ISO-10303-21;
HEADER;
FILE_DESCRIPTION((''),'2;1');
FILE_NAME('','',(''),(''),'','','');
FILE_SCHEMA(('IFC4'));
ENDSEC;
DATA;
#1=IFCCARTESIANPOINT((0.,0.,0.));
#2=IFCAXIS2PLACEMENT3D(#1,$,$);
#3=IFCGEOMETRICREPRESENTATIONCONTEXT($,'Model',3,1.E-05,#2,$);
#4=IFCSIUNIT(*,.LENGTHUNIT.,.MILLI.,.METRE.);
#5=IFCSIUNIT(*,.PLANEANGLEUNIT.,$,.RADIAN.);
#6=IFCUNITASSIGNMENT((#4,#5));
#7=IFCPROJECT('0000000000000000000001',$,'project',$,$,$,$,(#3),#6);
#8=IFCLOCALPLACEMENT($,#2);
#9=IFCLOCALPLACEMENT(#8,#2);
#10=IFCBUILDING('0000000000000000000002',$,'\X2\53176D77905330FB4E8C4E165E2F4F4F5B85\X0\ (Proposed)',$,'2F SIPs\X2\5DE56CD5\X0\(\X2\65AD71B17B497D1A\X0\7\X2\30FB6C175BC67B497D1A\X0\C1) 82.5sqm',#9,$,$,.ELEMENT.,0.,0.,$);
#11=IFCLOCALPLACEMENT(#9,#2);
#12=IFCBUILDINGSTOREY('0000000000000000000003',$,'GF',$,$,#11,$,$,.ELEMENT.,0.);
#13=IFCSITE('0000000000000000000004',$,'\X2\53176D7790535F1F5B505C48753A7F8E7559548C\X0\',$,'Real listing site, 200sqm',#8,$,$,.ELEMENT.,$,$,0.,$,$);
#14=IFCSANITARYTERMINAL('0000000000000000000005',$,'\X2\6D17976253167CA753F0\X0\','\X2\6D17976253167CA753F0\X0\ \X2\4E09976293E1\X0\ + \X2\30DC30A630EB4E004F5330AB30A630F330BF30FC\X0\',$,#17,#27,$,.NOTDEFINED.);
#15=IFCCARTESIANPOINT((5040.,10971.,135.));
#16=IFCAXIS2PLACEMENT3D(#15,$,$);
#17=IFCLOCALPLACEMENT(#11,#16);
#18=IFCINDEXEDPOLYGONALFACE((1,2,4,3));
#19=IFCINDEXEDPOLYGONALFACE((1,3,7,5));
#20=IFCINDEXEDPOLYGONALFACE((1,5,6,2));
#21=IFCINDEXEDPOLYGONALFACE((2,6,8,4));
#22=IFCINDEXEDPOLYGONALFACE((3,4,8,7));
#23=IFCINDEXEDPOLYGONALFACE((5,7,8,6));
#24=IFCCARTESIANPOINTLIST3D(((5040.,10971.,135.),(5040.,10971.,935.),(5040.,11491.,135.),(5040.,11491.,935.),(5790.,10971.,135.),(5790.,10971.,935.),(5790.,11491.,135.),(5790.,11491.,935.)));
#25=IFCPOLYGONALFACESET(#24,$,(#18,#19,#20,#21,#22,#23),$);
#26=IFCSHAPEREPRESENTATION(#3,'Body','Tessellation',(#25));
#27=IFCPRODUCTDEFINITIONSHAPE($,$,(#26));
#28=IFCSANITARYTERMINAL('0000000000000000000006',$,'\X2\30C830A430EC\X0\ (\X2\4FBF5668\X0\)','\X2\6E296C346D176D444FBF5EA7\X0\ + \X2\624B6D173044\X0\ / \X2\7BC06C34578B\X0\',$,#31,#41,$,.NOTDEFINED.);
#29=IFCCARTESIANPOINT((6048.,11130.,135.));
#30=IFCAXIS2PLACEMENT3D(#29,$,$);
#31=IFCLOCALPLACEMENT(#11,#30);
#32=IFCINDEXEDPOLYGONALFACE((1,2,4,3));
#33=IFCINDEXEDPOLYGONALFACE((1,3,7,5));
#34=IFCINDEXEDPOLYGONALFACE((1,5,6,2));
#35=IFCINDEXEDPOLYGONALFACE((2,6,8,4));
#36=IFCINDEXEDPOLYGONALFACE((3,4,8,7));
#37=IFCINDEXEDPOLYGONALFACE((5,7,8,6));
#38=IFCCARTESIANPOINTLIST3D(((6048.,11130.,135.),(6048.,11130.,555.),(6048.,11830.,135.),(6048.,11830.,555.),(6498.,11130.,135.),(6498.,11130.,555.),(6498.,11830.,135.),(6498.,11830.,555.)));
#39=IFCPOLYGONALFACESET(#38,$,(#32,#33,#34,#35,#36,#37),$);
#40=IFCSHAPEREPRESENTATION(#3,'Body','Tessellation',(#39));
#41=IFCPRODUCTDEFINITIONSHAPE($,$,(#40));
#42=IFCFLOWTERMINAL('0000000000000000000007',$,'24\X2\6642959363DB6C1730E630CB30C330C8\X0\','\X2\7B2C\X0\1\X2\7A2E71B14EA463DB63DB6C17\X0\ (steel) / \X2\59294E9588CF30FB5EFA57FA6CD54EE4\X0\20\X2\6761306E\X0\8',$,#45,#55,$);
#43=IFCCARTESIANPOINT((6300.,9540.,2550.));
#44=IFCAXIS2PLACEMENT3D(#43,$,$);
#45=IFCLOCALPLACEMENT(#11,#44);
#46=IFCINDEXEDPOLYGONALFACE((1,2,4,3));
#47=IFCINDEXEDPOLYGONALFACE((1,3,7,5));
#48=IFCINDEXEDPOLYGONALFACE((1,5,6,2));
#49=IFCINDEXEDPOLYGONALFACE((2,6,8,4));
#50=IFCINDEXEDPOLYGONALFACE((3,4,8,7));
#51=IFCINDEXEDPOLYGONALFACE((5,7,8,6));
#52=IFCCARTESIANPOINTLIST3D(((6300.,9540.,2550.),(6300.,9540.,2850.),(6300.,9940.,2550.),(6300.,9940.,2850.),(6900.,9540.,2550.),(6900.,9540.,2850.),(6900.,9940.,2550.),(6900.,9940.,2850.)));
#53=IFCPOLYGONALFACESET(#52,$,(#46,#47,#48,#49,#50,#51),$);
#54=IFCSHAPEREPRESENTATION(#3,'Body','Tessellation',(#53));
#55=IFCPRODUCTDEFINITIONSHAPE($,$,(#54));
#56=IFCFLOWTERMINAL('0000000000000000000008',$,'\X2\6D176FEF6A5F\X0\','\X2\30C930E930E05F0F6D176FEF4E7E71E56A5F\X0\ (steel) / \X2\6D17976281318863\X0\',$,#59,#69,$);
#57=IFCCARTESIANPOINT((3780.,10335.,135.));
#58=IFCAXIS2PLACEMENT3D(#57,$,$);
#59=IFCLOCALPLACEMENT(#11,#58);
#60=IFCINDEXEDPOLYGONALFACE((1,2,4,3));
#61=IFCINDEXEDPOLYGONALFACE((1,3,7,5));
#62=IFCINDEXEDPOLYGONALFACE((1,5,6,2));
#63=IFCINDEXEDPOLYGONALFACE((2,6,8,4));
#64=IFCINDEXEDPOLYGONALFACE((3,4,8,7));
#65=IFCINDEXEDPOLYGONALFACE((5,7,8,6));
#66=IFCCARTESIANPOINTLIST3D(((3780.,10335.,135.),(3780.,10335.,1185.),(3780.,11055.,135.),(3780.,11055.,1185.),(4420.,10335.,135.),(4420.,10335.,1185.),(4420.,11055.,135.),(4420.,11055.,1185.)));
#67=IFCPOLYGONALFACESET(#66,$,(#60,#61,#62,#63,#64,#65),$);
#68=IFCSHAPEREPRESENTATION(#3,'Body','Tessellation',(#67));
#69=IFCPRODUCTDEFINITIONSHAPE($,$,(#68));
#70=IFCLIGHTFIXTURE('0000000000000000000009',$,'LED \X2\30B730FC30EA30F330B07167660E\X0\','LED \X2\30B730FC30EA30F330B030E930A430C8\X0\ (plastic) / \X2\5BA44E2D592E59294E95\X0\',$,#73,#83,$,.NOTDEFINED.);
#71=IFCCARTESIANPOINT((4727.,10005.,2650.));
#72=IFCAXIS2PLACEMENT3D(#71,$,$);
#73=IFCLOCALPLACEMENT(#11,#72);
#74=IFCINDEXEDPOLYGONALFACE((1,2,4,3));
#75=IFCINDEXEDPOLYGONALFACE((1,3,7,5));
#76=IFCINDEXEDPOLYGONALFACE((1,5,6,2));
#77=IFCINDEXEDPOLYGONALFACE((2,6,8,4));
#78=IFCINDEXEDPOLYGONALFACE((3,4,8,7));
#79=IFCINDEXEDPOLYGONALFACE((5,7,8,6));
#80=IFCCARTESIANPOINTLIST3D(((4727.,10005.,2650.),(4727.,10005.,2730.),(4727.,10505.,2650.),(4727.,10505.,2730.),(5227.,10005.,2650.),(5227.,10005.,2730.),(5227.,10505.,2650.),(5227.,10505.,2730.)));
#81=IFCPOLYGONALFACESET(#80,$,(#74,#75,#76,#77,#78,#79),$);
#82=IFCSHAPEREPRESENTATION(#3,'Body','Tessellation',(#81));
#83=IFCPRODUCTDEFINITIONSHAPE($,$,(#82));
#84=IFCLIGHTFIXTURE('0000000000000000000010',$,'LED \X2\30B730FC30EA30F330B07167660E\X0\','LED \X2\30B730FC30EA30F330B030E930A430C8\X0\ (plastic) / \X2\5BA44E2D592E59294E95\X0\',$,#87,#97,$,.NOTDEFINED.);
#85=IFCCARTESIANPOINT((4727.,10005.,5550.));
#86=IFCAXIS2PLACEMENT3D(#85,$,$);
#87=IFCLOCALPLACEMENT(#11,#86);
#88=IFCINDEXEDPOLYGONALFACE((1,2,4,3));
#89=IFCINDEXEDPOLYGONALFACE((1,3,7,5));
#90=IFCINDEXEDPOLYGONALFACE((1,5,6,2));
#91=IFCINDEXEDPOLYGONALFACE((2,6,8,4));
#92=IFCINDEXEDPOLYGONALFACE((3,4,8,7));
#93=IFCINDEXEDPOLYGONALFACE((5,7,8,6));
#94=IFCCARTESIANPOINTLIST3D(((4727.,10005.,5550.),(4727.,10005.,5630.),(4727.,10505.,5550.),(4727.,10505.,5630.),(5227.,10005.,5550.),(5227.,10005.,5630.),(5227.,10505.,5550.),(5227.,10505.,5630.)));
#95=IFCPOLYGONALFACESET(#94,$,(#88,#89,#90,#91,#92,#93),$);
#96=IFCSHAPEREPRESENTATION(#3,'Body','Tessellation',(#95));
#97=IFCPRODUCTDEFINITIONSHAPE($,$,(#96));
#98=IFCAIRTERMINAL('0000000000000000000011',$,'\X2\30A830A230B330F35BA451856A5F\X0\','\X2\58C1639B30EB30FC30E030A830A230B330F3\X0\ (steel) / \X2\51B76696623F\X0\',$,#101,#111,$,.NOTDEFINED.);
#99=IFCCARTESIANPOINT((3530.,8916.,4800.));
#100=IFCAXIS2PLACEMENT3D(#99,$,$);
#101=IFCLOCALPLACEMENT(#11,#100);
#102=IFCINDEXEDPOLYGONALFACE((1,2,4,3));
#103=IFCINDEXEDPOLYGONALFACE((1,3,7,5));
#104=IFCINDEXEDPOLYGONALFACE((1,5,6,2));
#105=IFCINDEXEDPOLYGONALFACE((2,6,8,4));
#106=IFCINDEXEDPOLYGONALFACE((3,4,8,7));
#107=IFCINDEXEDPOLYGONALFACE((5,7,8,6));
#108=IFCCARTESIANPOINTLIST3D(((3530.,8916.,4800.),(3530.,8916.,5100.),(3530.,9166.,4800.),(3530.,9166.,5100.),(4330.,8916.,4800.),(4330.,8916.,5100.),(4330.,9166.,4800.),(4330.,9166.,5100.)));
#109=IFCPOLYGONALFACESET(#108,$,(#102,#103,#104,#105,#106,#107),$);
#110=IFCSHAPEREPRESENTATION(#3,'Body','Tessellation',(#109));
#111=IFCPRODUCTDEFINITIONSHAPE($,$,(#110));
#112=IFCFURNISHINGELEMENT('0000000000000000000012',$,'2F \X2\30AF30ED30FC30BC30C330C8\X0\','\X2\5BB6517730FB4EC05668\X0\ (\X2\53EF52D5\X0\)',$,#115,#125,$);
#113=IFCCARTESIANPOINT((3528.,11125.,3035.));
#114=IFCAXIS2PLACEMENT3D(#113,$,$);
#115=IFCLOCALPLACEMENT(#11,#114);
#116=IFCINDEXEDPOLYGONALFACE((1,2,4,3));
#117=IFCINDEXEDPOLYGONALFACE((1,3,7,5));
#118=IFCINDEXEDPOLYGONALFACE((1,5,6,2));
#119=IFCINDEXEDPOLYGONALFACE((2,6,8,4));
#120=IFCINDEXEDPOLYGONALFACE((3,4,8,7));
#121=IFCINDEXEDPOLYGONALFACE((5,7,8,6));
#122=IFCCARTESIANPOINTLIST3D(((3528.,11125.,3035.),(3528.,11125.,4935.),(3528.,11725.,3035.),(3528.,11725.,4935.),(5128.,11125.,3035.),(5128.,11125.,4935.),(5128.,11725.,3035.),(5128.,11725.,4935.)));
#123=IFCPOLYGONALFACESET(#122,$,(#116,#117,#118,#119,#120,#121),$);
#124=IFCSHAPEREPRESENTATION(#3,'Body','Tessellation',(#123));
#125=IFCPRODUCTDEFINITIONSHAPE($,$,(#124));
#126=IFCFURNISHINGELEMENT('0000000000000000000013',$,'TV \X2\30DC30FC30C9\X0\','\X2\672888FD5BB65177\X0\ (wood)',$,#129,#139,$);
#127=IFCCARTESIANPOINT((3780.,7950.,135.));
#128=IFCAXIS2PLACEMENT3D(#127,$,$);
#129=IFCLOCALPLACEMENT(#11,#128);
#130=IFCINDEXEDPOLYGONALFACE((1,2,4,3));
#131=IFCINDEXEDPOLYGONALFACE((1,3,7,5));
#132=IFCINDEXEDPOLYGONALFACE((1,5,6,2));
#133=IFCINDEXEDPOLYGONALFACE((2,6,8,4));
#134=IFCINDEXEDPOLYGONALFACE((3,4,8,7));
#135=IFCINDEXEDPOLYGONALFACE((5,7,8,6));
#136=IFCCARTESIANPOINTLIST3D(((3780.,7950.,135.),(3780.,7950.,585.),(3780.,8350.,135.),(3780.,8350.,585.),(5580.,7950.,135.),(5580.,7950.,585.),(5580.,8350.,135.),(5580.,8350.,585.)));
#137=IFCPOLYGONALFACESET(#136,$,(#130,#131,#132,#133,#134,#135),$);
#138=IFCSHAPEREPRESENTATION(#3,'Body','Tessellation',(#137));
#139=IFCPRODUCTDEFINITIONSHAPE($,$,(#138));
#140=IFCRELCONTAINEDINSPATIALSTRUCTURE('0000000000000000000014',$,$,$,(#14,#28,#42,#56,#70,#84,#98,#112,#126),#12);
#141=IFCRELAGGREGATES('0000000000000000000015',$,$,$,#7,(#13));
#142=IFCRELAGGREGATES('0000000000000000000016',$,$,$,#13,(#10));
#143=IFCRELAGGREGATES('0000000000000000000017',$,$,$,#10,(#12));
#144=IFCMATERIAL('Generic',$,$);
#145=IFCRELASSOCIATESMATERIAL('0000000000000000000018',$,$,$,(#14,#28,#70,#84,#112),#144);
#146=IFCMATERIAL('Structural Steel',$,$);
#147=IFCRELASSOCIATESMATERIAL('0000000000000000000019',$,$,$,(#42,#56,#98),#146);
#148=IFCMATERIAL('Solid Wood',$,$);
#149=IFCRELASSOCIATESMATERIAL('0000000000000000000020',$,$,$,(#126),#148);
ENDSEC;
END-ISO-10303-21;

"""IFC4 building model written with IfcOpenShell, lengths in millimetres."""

from ifc_helpers import new_model, si_unit, frame, frame_2d, origin, place, context, project, spatial, rectangle, extrude, material, element, save


model = new_model("IFC4")

# Units and contexts
model_context = context("Model", 3, precision=1e-05, world=origin())
ifc_project = project(units=[si_unit("LENGTHUNIT", "METRE", prefix="MILLI"), si_unit("PLANEANGLEUNIT", "RADIAN")], contexts=[model_context])

# Site, building, storey
site_placement = place(None, origin())
site = spatial("IfcSite", under=ifc_project, at=site_placement, Name="北海道弟子屈町美留和", ObjectType="Real listing site, 200sqm", CompositionType="ELEMENT", RefElevation=0.0)
building_placement = place(site_placement, origin())
building = spatial("IfcBuilding", under=site, at=building_placement, Name="北海道・二世帯住宅 (Proposed)", ObjectType="2F SIPs工法(断熱等級7・気密等級C1) 82.5sqm", CompositionType="ELEMENT", ElevationOfRefHeight=0.0, ElevationOfTerrain=0.0)
storey_placement = place(building_placement, origin())
storey = spatial("IfcBuildingStorey", under=building, at=storey_placement, Name="GF", CompositionType="ELEMENT", Elevation=0.0)

# Shared definitions
ifc_material_1 = material(Name="Solid Wood")

# Sanitary terminals
ifc_material_2 = material(Name="Generic")
sanitary_terminal_1_placement = place(storey_placement, frame((5040.0, 10971.0, 135.0)))
element("IfcSanitaryTerminal", 1, at=sanitary_terminal_1_placement, inside=storey, material=ifc_material_2, Name="洗面化粧台", Description="洗面化粧台 三面鏡 + ボウル一体カウンター", PredefinedType="NOTDEFINED", context=model_context, shape_type="SweptSolid", body=[
    extrude(rectangle(XDim=750.0, YDim=520.0, at=frame_2d((375.0, 260.0))), frame((5040.0, 10971.0, 135.0)), (0.0, 0.0, 1.0), 800.0),
])
sanitary_terminal_2_placement = place(storey_placement, frame((6048.0, 11130.0, 135.0)))
element("IfcSanitaryTerminal", 2, at=sanitary_terminal_2_placement, inside=storey, material=ifc_material_2, Name="トイレ (便器)", Description="温水洗浄便座 + 手洗い / 節水型", PredefinedType="NOTDEFINED", context=model_context, shape_type="SweptSolid", body=[
    extrude(rectangle(XDim=450.0, YDim=700.0, at=frame_2d((225.0, 350.0))), frame((6048.0, 11130.0, 135.0)), (0.0, 0.0, 1.0), 420.0),
])

# Flow terminals
ifc_material_3 = material(Name="Structural Steel")
flow_terminal_1_placement = place(storey_placement, frame((6300.0, 9540.0, 2550.0)))
element("IfcFlowTerminal", 3, at=flow_terminal_1_placement, inside=storey, material=ifc_material_3, Name="24時間換気ユニット", Description="第1種熱交換換気 (steel) / 天井裏・建基法令20条の8", context=model_context, shape_type="SweptSolid", body=[
    extrude(rectangle(XDim=600.0, YDim=400.0, at=frame_2d((300.0, 200.0))), frame((6300.0, 9540.0, 2550.0)), (0.0, 0.0, 1.0), 300.0),
])
flow_terminal_2_placement = place(storey_placement, frame((3780.0, 10335.0, 135.0)))
element("IfcFlowTerminal", 4, at=flow_terminal_2_placement, inside=storey, material=ifc_material_3, Name="洗濯機", Description="ドラム式洗濯乾燥機 (steel) / 洗面脱衣", context=model_context, shape_type="SweptSolid", body=[
    extrude(rectangle(XDim=640.0, YDim=720.0, at=frame_2d((320.0, 360.0))), frame((3780.0, 10335.0, 135.0)), (0.0, 0.0, 1.0), 1050.0),
])

# Light fixtures
light_fixture_1_placement = place(storey_placement, frame((4727.0, 10005.0, 2650.0)))
element("IfcLightFixture", 5, at=light_fixture_1_placement, inside=storey, material=ifc_material_2, Name="LED シーリング照明", Description="LED シーリングライト (plastic) / 室中央天井", PredefinedType="NOTDEFINED", context=model_context, shape_type="SweptSolid", body=[
    extrude(rectangle(XDim=500.0, YDim=500.0, at=frame_2d((250.0, 250.0))), frame((4727.0, 10005.0, 2650.0)), (0.0, 0.0, 1.0), 80.0),
])
light_fixture_2_placement = place(storey_placement, frame((4727.0, 10005.0, 5550.0)))
element("IfcLightFixture", 6, at=light_fixture_2_placement, inside=storey, material=ifc_material_2, Name="LED シーリング照明", Description="LED シーリングライト (plastic) / 室中央天井", PredefinedType="NOTDEFINED", context=model_context, shape_type="SweptSolid", body=[
    extrude(rectangle(XDim=500.0, YDim=500.0, at=frame_2d((250.0, 250.0))), frame((4727.0, 10005.0, 5550.0)), (0.0, 0.0, 1.0), 80.0),
])

# Air terminal
air_terminal_placement = place(storey_placement, frame((3530.0, 8916.0, 4800.0)))
element("IfcAirTerminal", 7, at=air_terminal_placement, inside=storey, material=ifc_material_3, Name="エアコン室内機", Description="壁掛ルームエアコン (steel) / 冷暖房", PredefinedType="NOTDEFINED", context=model_context, shape_type="SweptSolid", body=[
    extrude(rectangle(XDim=800.0, YDim=250.0, at=frame_2d((400.0, 125.0))), frame((3530.0, 8916.0, 4800.0)), (0.0, 0.0, 1.0), 300.0),
])

# Furnishing elements
furnishing_1_placement = place(storey_placement, frame((3528.0, 11125.0, 3035.0)))
element("IfcFurnishingElement", 8, at=furnishing_1_placement, inside=storey, material=ifc_material_2, Name="2F クローゼット", Description="家具・什器 (可動)", context=model_context, shape_type="SweptSolid", body=[
    extrude(rectangle(XDim=1600.0, YDim=600.0, at=frame_2d((800.0, 300.0))), frame((3528.0, 11125.0, 3035.0)), (0.0, 0.0, 1.0), 1900.0),
])
furnishing_2_placement = place(storey_placement, frame((3780.0, 7950.0, 135.0)))
element("IfcFurnishingElement", 9, at=furnishing_2_placement, inside=storey, material=ifc_material_1, Name="TV ボード", Description="木製家具 (wood)", context=model_context, shape_type="SweptSolid", body=[
    extrude(rectangle(XDim=1800.0, YDim=400.0, at=frame_2d((900.0, 200.0))), frame((3780.0, 7950.0, 135.0)), (0.0, 0.0, 1.0), 450.0),
])

save(model, "model.ifc")
